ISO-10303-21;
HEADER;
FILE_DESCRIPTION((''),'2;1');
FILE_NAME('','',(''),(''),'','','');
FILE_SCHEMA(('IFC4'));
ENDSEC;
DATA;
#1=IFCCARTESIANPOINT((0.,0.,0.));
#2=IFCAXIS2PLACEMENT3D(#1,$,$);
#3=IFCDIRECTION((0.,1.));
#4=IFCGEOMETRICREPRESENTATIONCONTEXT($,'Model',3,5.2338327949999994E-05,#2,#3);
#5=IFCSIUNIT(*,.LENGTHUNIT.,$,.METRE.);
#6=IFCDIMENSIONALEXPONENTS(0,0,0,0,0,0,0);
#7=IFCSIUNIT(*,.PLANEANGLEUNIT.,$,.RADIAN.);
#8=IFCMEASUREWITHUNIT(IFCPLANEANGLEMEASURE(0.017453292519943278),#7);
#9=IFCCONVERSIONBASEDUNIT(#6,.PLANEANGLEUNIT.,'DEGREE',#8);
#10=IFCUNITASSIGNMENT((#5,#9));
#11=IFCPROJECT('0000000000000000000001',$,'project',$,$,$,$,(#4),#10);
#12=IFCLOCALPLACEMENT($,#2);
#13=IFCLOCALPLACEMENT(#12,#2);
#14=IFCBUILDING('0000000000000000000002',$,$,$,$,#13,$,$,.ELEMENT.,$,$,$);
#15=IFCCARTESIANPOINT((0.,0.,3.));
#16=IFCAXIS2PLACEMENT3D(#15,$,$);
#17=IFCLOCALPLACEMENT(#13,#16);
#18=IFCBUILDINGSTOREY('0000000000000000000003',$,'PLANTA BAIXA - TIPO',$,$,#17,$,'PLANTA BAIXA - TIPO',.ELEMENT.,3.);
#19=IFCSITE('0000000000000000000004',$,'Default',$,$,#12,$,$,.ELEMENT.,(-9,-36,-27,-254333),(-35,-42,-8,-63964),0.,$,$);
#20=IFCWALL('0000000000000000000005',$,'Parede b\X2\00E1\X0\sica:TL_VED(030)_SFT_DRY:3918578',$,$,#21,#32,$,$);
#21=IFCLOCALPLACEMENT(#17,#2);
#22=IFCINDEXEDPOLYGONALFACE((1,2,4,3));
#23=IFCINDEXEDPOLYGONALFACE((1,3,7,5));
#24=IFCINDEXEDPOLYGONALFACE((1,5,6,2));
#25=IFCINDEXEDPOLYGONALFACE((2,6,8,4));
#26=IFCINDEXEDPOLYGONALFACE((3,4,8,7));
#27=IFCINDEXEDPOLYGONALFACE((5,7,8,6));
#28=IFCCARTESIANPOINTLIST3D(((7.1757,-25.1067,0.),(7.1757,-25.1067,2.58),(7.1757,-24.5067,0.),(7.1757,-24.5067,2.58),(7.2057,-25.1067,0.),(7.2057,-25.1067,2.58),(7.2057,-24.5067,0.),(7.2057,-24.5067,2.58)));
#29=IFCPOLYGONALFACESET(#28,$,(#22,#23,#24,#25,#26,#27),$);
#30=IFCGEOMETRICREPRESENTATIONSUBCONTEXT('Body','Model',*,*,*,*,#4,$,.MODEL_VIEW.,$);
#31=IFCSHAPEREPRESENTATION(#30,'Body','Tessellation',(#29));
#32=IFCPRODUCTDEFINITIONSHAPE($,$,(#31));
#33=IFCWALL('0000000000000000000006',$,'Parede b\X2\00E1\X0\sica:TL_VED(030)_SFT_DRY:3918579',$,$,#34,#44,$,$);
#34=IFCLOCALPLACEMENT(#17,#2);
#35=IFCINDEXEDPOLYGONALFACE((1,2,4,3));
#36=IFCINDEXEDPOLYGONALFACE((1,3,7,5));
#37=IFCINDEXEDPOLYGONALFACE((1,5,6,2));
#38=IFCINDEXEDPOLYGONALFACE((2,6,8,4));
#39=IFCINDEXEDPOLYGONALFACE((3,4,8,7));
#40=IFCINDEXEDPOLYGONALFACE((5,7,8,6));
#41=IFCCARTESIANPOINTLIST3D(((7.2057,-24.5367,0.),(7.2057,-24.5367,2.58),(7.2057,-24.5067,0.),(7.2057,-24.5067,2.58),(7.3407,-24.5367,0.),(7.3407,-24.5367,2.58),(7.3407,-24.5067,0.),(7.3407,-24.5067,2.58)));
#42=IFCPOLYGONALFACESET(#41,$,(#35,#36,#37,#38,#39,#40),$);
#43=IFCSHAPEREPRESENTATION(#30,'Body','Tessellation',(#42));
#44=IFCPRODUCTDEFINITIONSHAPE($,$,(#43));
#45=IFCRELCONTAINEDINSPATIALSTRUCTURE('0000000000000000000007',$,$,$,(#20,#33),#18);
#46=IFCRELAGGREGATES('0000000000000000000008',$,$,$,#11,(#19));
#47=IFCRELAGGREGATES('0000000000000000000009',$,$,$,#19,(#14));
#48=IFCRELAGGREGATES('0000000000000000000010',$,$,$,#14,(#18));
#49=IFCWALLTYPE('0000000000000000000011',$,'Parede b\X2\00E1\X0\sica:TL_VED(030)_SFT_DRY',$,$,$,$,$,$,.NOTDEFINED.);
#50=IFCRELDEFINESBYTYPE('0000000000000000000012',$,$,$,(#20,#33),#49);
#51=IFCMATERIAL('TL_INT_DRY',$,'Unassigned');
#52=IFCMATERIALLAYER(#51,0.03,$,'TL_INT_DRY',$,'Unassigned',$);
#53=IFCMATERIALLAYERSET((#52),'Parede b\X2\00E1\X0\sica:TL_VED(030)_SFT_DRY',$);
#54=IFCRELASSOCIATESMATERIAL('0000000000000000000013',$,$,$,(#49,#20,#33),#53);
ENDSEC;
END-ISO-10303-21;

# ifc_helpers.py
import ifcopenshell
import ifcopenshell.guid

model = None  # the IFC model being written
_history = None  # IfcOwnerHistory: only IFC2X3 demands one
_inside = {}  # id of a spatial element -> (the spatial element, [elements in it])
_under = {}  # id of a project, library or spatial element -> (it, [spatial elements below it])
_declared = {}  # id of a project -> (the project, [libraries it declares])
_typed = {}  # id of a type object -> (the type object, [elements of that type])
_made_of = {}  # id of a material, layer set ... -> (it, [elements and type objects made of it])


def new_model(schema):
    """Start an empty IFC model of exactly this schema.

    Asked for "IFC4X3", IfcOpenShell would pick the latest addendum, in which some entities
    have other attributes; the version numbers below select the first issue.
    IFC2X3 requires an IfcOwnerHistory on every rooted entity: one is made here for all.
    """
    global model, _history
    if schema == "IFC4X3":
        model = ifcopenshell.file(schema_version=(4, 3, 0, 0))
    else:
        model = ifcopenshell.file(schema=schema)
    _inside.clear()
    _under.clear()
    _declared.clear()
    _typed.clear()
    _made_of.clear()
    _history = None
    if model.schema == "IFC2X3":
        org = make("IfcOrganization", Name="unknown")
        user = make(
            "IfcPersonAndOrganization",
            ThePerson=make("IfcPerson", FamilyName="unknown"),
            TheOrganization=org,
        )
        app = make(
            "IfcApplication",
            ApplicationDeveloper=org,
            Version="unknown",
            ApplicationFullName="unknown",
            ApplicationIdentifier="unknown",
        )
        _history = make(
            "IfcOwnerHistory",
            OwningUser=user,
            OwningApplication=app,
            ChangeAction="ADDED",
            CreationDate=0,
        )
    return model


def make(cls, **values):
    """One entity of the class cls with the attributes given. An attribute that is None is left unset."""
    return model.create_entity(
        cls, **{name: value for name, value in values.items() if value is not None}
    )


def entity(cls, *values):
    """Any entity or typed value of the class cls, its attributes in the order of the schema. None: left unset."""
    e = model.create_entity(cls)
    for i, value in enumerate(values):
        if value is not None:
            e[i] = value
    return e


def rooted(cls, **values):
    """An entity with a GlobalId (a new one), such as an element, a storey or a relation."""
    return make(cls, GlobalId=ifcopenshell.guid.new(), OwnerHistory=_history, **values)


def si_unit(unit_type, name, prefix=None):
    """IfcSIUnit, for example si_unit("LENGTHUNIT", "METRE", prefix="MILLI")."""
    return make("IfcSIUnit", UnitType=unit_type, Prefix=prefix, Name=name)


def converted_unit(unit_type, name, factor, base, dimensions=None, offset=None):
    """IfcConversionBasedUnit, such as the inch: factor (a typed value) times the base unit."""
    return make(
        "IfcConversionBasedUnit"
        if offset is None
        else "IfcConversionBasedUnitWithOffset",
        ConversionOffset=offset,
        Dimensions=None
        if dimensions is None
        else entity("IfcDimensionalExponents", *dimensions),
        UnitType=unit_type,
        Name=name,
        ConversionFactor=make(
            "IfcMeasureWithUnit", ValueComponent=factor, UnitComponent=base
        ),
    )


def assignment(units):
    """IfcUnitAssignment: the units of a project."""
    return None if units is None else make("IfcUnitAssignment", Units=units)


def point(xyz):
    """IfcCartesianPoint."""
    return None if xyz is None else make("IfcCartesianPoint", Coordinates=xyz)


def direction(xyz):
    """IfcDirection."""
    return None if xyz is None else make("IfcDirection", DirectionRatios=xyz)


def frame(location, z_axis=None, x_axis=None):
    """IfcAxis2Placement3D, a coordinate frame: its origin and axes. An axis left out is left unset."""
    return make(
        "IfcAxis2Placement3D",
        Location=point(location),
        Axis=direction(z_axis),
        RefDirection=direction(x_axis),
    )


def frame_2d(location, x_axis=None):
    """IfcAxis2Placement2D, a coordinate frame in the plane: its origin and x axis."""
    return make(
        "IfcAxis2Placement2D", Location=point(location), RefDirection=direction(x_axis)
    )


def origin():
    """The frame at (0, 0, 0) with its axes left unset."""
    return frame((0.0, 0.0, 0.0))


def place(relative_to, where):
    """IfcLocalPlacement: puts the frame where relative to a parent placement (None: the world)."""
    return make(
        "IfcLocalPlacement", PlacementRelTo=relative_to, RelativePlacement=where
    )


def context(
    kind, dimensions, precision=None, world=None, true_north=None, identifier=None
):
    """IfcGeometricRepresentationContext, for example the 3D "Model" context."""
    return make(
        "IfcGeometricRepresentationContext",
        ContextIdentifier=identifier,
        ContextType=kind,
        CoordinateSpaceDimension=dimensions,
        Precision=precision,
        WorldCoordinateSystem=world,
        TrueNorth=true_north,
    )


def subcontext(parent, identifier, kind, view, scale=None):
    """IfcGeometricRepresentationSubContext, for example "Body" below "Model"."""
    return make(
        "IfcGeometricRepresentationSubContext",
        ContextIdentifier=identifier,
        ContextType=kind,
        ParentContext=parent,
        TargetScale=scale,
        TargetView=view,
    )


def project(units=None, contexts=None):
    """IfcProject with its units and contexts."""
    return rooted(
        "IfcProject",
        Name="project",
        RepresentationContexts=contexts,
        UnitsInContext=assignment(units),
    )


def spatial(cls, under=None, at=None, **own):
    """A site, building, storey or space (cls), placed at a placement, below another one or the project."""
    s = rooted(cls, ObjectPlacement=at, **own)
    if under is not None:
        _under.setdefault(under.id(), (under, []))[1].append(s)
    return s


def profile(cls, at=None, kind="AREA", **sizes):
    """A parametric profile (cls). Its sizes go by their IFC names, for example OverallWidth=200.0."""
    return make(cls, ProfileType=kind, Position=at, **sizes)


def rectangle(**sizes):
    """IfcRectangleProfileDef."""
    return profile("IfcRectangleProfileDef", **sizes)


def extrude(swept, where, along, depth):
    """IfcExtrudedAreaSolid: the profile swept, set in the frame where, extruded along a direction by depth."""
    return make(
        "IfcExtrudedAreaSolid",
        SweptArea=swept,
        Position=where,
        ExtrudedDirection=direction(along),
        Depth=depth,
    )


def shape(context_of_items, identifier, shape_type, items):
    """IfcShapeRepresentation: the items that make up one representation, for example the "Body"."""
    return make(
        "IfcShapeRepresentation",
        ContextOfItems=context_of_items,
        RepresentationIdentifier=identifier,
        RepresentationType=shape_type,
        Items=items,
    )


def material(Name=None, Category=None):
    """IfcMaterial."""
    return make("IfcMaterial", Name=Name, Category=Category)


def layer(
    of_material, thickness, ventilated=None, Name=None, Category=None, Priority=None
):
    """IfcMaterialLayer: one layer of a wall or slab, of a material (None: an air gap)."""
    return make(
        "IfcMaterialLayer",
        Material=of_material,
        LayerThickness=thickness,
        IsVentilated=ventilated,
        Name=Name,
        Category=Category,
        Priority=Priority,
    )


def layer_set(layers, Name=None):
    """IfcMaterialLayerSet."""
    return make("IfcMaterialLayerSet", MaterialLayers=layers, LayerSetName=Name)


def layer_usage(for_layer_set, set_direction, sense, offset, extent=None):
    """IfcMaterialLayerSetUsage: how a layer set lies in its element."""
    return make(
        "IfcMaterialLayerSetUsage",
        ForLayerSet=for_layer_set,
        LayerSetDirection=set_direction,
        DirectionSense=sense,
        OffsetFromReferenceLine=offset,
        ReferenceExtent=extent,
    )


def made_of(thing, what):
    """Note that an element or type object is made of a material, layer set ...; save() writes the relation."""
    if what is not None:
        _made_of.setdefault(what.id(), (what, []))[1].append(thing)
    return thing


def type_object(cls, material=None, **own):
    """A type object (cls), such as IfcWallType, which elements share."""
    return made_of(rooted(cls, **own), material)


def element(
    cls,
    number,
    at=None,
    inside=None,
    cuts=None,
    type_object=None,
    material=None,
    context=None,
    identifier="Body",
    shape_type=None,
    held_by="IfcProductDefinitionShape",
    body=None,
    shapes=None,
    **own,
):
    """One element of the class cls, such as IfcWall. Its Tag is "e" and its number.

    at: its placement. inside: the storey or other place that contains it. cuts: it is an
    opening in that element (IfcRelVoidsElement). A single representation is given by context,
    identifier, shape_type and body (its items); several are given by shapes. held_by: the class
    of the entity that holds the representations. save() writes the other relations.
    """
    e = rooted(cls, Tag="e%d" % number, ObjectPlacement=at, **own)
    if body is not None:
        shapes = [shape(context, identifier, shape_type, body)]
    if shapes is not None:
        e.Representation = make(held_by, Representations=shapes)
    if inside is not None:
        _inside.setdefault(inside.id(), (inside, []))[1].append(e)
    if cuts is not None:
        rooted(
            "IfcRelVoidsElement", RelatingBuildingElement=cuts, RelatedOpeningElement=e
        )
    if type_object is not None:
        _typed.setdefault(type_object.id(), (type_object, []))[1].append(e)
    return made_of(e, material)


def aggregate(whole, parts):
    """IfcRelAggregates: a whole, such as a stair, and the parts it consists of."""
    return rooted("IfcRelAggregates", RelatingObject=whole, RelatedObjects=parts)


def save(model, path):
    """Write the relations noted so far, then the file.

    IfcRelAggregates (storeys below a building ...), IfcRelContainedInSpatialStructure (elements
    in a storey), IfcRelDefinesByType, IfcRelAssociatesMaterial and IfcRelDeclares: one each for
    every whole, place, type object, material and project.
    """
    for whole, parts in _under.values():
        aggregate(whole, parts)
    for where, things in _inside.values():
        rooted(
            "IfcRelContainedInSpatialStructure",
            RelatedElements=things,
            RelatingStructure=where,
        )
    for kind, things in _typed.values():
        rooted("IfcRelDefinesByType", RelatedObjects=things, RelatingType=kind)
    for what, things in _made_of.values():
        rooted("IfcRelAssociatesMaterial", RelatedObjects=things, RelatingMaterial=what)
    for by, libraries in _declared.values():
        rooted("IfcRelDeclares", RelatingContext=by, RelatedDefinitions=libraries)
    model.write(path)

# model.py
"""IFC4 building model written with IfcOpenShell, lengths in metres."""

from ifc_helpers import new_model, entity, si_unit, converted_unit, direction, frame, frame_2d, origin, place, context, subcontext, project, spatial, rectangle, extrude, material, layer, layer_set, layer_usage, type_object, element, save


model = new_model("IFC4")

# Units and contexts
model_context = context("Model", 3, precision=5.2338327949999994e-05, world=origin(), true_north=direction((0.0, 1.0)))
body_context = subcontext(model_context, "Body", "Model", "MODEL_VIEW")
ifc_project = project(units=[si_unit("LENGTHUNIT", "METRE"), converted_unit("PLANEANGLEUNIT", "DEGREE", entity("IfcPlaneAngleMeasure", 0.017453292519943278), si_unit("PLANEANGLEUNIT", "RADIAN"), dimensions=[0, 0, 0, 0, 0, 0, 0])], contexts=[model_context])

# Site, building, storey
site_placement = place(None, frame((0.0, 0.0, 0.0)))
site = spatial("IfcSite", under=ifc_project, at=site_placement, Name="Default", CompositionType="ELEMENT", RefLatitude=(-9, -36, -27, -254333), RefLongitude=(-35, -42, -8, -63964), RefElevation=0.0)
building_placement = place(site_placement, origin())
building = spatial("IfcBuilding", under=site, at=building_placement, CompositionType="ELEMENT")
storey_placement = place(building_placement, frame((0.0, 0.0, 3.0)))
storey = spatial("IfcBuildingStorey", under=building, at=storey_placement, Name="PLANTA BAIXA - TIPO", LongName="PLANTA BAIXA - TIPO", CompositionType="ELEMENT", Elevation=3.0)

# Walls
ifc_material_1 = material(Name="TL_INT_DRY", Category="Unassigned")
ifc_layer_1 = layer(ifc_material_1, 0.03, Name="TL_INT_DRY", Category="Unassigned")
ifc_layer_set_1 = layer_set([ifc_layer_1], Name="Parede básica:TL_VED(030)_SFT_DRY")
ifc_layer_usage_1 = layer_usage(ifc_layer_set_1, "AXIS2", "NEGATIVE", 0.015)
wall_type_1 = type_object("IfcWallType", Name="Parede básica:TL_VED(030)_SFT_DRY", PredefinedType="NOTDEFINED", material=ifc_layer_set_1)
wall_1_placement = place(storey_placement, frame((7.1907, -25.1067, 0.0), z_axis=(0.0, 0.0, 1.0), x_axis=(0.0, 1.0, 0.0)))
element("IfcWall", 1, at=wall_1_placement, inside=storey, type_object=wall_type_1, material=ifc_layer_usage_1, Name="Parede básica:TL_VED(030)_SFT_DRY:3918578", context=body_context, shape_type="SweptSolid", body=[
    extrude(rectangle(XDim=0.6, YDim=0.03, at=frame_2d((0.3, 0.0), x_axis=(-1.0, 0.0))), origin(), (0.0, 0.0, 1.0), 2.58),
])
ifc_layer_usage_2 = layer_usage(ifc_layer_set_1, "AXIS2", "NEGATIVE", 0.015)
wall_2_placement = place(storey_placement, frame((7.2057, -24.5217, 0.0)))
element("IfcWall", 2, at=wall_2_placement, inside=storey, type_object=wall_type_1, material=ifc_layer_usage_2, Name="Parede básica:TL_VED(030)_SFT_DRY:3918579", context=body_context, shape_type="SweptSolid", body=[
    extrude(rectangle(XDim=0.135, YDim=0.03, at=frame_2d((0.0675, 0.0), x_axis=(-1.0, 0.0))), origin(), (0.0, 0.0, 1.0), 2.58),
])

save(model, "model.ifc")
